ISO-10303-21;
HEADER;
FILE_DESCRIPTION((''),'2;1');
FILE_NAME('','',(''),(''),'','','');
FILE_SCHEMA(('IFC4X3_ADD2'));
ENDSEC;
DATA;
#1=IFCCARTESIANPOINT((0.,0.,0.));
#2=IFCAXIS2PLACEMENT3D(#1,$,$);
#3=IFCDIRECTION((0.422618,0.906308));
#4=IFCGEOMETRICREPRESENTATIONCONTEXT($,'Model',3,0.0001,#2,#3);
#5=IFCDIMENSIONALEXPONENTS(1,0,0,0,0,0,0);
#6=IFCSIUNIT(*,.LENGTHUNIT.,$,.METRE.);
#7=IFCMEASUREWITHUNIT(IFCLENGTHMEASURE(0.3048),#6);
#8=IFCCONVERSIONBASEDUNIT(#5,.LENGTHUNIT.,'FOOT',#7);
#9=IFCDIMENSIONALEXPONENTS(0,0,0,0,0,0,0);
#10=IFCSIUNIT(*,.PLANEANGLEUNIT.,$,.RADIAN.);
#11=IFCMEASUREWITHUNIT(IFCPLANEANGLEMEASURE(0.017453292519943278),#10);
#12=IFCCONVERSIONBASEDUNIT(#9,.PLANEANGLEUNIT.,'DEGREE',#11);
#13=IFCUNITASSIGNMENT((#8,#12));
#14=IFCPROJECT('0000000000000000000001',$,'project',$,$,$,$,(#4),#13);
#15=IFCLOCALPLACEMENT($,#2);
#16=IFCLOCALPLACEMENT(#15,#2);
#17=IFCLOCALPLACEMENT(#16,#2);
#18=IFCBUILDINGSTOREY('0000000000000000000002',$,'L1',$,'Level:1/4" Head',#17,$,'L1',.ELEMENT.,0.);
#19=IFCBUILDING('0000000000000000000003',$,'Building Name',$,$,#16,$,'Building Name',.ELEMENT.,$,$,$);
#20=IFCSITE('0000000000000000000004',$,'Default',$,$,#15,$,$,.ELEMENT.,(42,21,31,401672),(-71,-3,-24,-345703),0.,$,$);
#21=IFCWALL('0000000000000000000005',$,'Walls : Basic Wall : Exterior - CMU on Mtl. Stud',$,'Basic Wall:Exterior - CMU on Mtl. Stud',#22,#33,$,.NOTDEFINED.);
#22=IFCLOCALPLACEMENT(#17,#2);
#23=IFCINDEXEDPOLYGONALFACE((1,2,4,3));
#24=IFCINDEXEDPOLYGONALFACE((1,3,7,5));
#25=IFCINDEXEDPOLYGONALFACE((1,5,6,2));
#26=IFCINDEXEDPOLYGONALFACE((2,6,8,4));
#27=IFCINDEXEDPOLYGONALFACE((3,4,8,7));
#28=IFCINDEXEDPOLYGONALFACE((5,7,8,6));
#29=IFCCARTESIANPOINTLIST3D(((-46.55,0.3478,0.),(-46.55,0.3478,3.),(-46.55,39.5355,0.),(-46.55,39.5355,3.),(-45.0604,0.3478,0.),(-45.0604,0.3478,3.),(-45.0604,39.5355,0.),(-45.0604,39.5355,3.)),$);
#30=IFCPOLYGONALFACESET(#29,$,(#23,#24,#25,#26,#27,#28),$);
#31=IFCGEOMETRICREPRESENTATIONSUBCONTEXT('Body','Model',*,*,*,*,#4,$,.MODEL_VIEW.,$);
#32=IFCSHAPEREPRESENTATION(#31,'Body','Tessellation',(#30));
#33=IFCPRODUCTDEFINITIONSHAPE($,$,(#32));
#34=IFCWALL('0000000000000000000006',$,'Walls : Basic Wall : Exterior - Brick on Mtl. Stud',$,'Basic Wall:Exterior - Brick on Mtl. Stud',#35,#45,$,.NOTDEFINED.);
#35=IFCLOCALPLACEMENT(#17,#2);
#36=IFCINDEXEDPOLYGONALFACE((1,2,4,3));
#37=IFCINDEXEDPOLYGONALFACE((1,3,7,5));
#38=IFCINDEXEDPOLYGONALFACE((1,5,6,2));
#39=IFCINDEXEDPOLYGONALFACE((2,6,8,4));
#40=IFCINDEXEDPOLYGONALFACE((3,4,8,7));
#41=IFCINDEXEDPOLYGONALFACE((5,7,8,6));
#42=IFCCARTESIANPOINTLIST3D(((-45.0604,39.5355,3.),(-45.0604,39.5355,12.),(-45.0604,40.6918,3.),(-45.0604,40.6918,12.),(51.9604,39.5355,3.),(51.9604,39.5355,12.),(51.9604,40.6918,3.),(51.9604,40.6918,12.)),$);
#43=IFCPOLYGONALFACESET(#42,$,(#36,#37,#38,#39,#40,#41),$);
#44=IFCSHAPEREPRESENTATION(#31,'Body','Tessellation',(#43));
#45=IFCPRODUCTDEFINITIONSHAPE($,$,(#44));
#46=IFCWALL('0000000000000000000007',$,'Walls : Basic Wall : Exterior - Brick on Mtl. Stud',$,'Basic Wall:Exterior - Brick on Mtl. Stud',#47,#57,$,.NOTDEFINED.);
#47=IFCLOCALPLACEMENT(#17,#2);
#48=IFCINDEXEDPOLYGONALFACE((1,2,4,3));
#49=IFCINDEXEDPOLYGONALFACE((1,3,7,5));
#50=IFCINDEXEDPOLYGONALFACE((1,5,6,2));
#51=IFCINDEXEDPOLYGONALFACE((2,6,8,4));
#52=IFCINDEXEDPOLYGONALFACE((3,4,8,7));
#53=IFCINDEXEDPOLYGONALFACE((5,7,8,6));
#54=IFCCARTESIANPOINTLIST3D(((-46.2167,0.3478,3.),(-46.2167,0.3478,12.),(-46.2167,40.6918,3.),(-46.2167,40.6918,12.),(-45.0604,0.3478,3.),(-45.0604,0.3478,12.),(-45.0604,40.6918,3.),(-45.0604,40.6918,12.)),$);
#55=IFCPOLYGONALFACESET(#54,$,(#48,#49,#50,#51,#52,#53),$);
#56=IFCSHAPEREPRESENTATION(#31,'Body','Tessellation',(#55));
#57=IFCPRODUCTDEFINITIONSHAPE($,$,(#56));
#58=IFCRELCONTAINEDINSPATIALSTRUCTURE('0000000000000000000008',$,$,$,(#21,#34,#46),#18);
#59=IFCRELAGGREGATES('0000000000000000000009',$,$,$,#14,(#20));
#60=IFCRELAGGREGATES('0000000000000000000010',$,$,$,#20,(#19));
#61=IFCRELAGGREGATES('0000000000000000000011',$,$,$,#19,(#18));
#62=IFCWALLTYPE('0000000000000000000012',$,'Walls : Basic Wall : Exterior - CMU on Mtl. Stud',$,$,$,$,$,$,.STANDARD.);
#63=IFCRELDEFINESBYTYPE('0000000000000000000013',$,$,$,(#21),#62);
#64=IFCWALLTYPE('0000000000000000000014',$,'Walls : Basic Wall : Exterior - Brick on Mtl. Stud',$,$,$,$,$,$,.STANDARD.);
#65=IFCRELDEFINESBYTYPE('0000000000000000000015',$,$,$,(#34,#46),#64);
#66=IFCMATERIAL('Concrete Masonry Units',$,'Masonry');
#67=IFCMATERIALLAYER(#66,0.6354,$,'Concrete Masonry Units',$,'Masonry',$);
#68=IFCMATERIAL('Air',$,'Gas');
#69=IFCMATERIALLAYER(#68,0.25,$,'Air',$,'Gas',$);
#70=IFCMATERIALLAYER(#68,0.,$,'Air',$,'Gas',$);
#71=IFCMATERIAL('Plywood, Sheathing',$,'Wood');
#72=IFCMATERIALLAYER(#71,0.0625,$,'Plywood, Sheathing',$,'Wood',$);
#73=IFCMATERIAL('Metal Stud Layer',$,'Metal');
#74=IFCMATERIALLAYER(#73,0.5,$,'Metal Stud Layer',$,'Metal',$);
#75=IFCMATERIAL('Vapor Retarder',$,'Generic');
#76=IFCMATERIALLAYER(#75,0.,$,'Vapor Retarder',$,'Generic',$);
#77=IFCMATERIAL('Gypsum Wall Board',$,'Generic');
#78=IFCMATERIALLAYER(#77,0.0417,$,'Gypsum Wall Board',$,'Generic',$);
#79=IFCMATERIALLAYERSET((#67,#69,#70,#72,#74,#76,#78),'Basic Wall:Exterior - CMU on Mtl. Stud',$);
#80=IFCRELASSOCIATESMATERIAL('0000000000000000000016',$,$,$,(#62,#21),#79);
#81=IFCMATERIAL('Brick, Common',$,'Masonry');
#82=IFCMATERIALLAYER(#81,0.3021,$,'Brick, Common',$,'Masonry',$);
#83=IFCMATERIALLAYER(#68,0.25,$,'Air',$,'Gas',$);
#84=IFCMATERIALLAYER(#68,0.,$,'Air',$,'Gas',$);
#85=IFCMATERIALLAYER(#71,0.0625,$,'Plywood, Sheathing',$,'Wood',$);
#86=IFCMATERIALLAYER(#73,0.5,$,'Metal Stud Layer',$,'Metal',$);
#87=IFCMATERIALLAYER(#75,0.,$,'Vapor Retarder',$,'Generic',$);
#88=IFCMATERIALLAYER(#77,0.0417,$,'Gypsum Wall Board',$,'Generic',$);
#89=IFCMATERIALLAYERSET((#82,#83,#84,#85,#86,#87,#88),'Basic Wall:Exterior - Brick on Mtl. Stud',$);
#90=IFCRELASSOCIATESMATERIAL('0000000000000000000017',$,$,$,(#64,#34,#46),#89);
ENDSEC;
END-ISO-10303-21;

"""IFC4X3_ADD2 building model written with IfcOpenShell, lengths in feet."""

from ifc_helpers import new_model, entity, si_unit, converted_unit, direction, frame, frame_2d, origin, place, context, subcontext, project, spatial, rectangle, extrude, material, layer, layer_set, type_object, element, save


model = new_model("IFC4X3_ADD2")

# Units and contexts
model_context = context("Model", 3, precision=0.0001, world=origin(), true_north=direction((0.422618, 0.906308)))
body_context = subcontext(model_context, "Body", "Model", "MODEL_VIEW")
ifc_project = project(units=[converted_unit("LENGTHUNIT", "FOOT", entity("IfcLengthMeasure", 0.3048), si_unit("LENGTHUNIT", "METRE"), dimensions=[1, 0, 0, 0, 0, 0, 0]), converted_unit("PLANEANGLEUNIT", "DEGREE", entity("IfcPlaneAngleMeasure", 0.017453292519943278), si_unit("PLANEANGLEUNIT", "RADIAN"), dimensions=[0, 0, 0, 0, 0, 0, 0])], contexts=[model_context])

# Site, building, storey
site_placement = place(None, origin())
site = spatial("IfcSite", under=ifc_project, at=site_placement, Name="Default", CompositionType="ELEMENT", RefLatitude=(42, 21, 31, 401672), RefLongitude=(-71, -3, -24, -345703), RefElevation=0.0)
building_placement = place(site_placement, origin())
building = spatial("IfcBuilding", under=site, at=building_placement, Name="Building Name", LongName="Building Name", CompositionType="ELEMENT")
storey_placement = place(building_placement, origin())
storey = spatial("IfcBuildingStorey", under=building, at=storey_placement, Name="L1", ObjectType="Level:1/4\" Head", LongName="L1", CompositionType="ELEMENT", Elevation=0.0)

# Walls
ifc_material_1 = material(Name="Concrete Masonry Units", Category="Masonry")
ifc_layer_1 = layer(ifc_material_1, 0.6354, Name="Concrete Masonry Units", Category="Masonry")
ifc_material_2 = material(Name="Air", Category="Gas")
ifc_layer_2 = layer(ifc_material_2, 0.25, Name="Air", Category="Gas")
ifc_layer_3 = layer(ifc_material_2, 0.0, Name="Air", Category="Gas")
ifc_material_3 = material(Name="Plywood, Sheathing", Category="Wood")
ifc_layer_4 = layer(ifc_material_3, 0.0625, Name="Plywood, Sheathing", Category="Wood")
ifc_material_4 = material(Name="Metal Stud Layer", Category="Metal")
ifc_layer_5 = layer(ifc_material_4, 0.5, Name="Metal Stud Layer", Category="Metal")
ifc_material_5 = material(Name="Vapor Retarder", Category="Generic")
ifc_layer_6 = layer(ifc_material_5, 0.0, Name="Vapor Retarder", Category="Generic")
ifc_material_6 = material(Name="Gypsum Wall Board", Category="Generic")
ifc_layer_7 = layer(ifc_material_6, 0.0417, Name="Gypsum Wall Board", Category="Generic")
ifc_layer_set_1 = layer_set([ifc_layer_1, ifc_layer_2, ifc_layer_3, ifc_layer_4, ifc_layer_5, ifc_layer_6, ifc_layer_7], Name="Basic Wall:Exterior - CMU on Mtl. Stud")
wall_type_1 = type_object("IfcWallType", Name="Walls : Basic Wall : Exterior - CMU on Mtl. Stud", PredefinedType="STANDARD", material=ifc_layer_set_1)
wall_1_placement = place(storey_placement, frame((-45.8052, 0.3478, 0.0), z_axis=(0.0, 0.0, 1.0), x_axis=(0.0, 1.0, 0.0)))
element("IfcWall", 1, at=wall_1_placement, inside=storey, type_object=wall_type_1, material=ifc_layer_set_1, Name="Walls : Basic Wall : Exterior - CMU on Mtl. Stud", ObjectType="Basic Wall:Exterior - CMU on Mtl. Stud", PredefinedType="NOTDEFINED", context=body_context, shape_type="SweptSolid", body=[
    extrude(rectangle(XDim=39.1877, YDim=1.4896, at=frame_2d((19.5939, 0.0), x_axis=(-1.0, 0.0))), origin(), (0.0, 0.0, 1.0), 3.0),
])
ifc_material_7 = material(Name="Brick, Common", Category="Masonry")
ifc_layer_8 = layer(ifc_material_7, 0.3021, Name="Brick, Common", Category="Masonry")
ifc_layer_9 = layer(ifc_material_2, 0.25, Name="Air", Category="Gas")
ifc_layer_10 = layer(ifc_material_2, 0.0, Name="Air", Category="Gas")
ifc_layer_11 = layer(ifc_material_3, 0.0625, Name="Plywood, Sheathing", Category="Wood")
ifc_layer_12 = layer(ifc_material_4, 0.5, Name="Metal Stud Layer", Category="Metal")
ifc_layer_13 = layer(ifc_material_5, 0.0, Name="Vapor Retarder", Category="Generic")
ifc_layer_14 = layer(ifc_material_6, 0.0417, Name="Gypsum Wall Board", Category="Generic")
ifc_layer_set_2 = layer_set([ifc_layer_8, ifc_layer_9, ifc_layer_10, ifc_layer_11, ifc_layer_12, ifc_layer_13, ifc_layer_14], Name="Basic Wall:Exterior - Brick on Mtl. Stud")
wall_type_2 = type_object("IfcWallType", Name="Walls : Basic Wall : Exterior - Brick on Mtl. Stud", PredefinedType="STANDARD", material=ifc_layer_set_2)
wall_2_placement = place(storey_placement, frame((-45.0604, 40.1136, 3.0)))
element("IfcWall", 2, at=wall_2_placement, inside=storey, type_object=wall_type_2, material=ifc_layer_set_2, Name="Walls : Basic Wall : Exterior - Brick on Mtl. Stud", ObjectType="Basic Wall:Exterior - Brick on Mtl. Stud", PredefinedType="NOTDEFINED", context=body_context, shape_type="SweptSolid", body=[
    extrude(rectangle(XDim=97.0208, YDim=1.1563, at=frame_2d((48.5104, 0.0), x_axis=(-1.0, 0.0))), origin(), (0.0, 0.0, 1.0), 9.0),
])
wall_3_placement = place(storey_placement, frame((-45.6385, 0.3478, 3.0), z_axis=(0.0, 0.0, 1.0), x_axis=(0.0, 1.0, 0.0)))
element("IfcWall", 3, at=wall_3_placement, inside=storey, type_object=wall_type_2, material=ifc_layer_set_2, Name="Walls : Basic Wall : Exterior - Brick on Mtl. Stud", ObjectType="Basic Wall:Exterior - Brick on Mtl. Stud", PredefinedType="NOTDEFINED", context=body_context, shape_type="SweptSolid", body=[
    extrude(rectangle(XDim=40.344, YDim=1.1562, at=frame_2d((20.172, 0.0), x_axis=(-1.0, 0.0))), origin(), (0.0, 0.0, 1.0), 9.0),
])

save(model, "model.ifc")
